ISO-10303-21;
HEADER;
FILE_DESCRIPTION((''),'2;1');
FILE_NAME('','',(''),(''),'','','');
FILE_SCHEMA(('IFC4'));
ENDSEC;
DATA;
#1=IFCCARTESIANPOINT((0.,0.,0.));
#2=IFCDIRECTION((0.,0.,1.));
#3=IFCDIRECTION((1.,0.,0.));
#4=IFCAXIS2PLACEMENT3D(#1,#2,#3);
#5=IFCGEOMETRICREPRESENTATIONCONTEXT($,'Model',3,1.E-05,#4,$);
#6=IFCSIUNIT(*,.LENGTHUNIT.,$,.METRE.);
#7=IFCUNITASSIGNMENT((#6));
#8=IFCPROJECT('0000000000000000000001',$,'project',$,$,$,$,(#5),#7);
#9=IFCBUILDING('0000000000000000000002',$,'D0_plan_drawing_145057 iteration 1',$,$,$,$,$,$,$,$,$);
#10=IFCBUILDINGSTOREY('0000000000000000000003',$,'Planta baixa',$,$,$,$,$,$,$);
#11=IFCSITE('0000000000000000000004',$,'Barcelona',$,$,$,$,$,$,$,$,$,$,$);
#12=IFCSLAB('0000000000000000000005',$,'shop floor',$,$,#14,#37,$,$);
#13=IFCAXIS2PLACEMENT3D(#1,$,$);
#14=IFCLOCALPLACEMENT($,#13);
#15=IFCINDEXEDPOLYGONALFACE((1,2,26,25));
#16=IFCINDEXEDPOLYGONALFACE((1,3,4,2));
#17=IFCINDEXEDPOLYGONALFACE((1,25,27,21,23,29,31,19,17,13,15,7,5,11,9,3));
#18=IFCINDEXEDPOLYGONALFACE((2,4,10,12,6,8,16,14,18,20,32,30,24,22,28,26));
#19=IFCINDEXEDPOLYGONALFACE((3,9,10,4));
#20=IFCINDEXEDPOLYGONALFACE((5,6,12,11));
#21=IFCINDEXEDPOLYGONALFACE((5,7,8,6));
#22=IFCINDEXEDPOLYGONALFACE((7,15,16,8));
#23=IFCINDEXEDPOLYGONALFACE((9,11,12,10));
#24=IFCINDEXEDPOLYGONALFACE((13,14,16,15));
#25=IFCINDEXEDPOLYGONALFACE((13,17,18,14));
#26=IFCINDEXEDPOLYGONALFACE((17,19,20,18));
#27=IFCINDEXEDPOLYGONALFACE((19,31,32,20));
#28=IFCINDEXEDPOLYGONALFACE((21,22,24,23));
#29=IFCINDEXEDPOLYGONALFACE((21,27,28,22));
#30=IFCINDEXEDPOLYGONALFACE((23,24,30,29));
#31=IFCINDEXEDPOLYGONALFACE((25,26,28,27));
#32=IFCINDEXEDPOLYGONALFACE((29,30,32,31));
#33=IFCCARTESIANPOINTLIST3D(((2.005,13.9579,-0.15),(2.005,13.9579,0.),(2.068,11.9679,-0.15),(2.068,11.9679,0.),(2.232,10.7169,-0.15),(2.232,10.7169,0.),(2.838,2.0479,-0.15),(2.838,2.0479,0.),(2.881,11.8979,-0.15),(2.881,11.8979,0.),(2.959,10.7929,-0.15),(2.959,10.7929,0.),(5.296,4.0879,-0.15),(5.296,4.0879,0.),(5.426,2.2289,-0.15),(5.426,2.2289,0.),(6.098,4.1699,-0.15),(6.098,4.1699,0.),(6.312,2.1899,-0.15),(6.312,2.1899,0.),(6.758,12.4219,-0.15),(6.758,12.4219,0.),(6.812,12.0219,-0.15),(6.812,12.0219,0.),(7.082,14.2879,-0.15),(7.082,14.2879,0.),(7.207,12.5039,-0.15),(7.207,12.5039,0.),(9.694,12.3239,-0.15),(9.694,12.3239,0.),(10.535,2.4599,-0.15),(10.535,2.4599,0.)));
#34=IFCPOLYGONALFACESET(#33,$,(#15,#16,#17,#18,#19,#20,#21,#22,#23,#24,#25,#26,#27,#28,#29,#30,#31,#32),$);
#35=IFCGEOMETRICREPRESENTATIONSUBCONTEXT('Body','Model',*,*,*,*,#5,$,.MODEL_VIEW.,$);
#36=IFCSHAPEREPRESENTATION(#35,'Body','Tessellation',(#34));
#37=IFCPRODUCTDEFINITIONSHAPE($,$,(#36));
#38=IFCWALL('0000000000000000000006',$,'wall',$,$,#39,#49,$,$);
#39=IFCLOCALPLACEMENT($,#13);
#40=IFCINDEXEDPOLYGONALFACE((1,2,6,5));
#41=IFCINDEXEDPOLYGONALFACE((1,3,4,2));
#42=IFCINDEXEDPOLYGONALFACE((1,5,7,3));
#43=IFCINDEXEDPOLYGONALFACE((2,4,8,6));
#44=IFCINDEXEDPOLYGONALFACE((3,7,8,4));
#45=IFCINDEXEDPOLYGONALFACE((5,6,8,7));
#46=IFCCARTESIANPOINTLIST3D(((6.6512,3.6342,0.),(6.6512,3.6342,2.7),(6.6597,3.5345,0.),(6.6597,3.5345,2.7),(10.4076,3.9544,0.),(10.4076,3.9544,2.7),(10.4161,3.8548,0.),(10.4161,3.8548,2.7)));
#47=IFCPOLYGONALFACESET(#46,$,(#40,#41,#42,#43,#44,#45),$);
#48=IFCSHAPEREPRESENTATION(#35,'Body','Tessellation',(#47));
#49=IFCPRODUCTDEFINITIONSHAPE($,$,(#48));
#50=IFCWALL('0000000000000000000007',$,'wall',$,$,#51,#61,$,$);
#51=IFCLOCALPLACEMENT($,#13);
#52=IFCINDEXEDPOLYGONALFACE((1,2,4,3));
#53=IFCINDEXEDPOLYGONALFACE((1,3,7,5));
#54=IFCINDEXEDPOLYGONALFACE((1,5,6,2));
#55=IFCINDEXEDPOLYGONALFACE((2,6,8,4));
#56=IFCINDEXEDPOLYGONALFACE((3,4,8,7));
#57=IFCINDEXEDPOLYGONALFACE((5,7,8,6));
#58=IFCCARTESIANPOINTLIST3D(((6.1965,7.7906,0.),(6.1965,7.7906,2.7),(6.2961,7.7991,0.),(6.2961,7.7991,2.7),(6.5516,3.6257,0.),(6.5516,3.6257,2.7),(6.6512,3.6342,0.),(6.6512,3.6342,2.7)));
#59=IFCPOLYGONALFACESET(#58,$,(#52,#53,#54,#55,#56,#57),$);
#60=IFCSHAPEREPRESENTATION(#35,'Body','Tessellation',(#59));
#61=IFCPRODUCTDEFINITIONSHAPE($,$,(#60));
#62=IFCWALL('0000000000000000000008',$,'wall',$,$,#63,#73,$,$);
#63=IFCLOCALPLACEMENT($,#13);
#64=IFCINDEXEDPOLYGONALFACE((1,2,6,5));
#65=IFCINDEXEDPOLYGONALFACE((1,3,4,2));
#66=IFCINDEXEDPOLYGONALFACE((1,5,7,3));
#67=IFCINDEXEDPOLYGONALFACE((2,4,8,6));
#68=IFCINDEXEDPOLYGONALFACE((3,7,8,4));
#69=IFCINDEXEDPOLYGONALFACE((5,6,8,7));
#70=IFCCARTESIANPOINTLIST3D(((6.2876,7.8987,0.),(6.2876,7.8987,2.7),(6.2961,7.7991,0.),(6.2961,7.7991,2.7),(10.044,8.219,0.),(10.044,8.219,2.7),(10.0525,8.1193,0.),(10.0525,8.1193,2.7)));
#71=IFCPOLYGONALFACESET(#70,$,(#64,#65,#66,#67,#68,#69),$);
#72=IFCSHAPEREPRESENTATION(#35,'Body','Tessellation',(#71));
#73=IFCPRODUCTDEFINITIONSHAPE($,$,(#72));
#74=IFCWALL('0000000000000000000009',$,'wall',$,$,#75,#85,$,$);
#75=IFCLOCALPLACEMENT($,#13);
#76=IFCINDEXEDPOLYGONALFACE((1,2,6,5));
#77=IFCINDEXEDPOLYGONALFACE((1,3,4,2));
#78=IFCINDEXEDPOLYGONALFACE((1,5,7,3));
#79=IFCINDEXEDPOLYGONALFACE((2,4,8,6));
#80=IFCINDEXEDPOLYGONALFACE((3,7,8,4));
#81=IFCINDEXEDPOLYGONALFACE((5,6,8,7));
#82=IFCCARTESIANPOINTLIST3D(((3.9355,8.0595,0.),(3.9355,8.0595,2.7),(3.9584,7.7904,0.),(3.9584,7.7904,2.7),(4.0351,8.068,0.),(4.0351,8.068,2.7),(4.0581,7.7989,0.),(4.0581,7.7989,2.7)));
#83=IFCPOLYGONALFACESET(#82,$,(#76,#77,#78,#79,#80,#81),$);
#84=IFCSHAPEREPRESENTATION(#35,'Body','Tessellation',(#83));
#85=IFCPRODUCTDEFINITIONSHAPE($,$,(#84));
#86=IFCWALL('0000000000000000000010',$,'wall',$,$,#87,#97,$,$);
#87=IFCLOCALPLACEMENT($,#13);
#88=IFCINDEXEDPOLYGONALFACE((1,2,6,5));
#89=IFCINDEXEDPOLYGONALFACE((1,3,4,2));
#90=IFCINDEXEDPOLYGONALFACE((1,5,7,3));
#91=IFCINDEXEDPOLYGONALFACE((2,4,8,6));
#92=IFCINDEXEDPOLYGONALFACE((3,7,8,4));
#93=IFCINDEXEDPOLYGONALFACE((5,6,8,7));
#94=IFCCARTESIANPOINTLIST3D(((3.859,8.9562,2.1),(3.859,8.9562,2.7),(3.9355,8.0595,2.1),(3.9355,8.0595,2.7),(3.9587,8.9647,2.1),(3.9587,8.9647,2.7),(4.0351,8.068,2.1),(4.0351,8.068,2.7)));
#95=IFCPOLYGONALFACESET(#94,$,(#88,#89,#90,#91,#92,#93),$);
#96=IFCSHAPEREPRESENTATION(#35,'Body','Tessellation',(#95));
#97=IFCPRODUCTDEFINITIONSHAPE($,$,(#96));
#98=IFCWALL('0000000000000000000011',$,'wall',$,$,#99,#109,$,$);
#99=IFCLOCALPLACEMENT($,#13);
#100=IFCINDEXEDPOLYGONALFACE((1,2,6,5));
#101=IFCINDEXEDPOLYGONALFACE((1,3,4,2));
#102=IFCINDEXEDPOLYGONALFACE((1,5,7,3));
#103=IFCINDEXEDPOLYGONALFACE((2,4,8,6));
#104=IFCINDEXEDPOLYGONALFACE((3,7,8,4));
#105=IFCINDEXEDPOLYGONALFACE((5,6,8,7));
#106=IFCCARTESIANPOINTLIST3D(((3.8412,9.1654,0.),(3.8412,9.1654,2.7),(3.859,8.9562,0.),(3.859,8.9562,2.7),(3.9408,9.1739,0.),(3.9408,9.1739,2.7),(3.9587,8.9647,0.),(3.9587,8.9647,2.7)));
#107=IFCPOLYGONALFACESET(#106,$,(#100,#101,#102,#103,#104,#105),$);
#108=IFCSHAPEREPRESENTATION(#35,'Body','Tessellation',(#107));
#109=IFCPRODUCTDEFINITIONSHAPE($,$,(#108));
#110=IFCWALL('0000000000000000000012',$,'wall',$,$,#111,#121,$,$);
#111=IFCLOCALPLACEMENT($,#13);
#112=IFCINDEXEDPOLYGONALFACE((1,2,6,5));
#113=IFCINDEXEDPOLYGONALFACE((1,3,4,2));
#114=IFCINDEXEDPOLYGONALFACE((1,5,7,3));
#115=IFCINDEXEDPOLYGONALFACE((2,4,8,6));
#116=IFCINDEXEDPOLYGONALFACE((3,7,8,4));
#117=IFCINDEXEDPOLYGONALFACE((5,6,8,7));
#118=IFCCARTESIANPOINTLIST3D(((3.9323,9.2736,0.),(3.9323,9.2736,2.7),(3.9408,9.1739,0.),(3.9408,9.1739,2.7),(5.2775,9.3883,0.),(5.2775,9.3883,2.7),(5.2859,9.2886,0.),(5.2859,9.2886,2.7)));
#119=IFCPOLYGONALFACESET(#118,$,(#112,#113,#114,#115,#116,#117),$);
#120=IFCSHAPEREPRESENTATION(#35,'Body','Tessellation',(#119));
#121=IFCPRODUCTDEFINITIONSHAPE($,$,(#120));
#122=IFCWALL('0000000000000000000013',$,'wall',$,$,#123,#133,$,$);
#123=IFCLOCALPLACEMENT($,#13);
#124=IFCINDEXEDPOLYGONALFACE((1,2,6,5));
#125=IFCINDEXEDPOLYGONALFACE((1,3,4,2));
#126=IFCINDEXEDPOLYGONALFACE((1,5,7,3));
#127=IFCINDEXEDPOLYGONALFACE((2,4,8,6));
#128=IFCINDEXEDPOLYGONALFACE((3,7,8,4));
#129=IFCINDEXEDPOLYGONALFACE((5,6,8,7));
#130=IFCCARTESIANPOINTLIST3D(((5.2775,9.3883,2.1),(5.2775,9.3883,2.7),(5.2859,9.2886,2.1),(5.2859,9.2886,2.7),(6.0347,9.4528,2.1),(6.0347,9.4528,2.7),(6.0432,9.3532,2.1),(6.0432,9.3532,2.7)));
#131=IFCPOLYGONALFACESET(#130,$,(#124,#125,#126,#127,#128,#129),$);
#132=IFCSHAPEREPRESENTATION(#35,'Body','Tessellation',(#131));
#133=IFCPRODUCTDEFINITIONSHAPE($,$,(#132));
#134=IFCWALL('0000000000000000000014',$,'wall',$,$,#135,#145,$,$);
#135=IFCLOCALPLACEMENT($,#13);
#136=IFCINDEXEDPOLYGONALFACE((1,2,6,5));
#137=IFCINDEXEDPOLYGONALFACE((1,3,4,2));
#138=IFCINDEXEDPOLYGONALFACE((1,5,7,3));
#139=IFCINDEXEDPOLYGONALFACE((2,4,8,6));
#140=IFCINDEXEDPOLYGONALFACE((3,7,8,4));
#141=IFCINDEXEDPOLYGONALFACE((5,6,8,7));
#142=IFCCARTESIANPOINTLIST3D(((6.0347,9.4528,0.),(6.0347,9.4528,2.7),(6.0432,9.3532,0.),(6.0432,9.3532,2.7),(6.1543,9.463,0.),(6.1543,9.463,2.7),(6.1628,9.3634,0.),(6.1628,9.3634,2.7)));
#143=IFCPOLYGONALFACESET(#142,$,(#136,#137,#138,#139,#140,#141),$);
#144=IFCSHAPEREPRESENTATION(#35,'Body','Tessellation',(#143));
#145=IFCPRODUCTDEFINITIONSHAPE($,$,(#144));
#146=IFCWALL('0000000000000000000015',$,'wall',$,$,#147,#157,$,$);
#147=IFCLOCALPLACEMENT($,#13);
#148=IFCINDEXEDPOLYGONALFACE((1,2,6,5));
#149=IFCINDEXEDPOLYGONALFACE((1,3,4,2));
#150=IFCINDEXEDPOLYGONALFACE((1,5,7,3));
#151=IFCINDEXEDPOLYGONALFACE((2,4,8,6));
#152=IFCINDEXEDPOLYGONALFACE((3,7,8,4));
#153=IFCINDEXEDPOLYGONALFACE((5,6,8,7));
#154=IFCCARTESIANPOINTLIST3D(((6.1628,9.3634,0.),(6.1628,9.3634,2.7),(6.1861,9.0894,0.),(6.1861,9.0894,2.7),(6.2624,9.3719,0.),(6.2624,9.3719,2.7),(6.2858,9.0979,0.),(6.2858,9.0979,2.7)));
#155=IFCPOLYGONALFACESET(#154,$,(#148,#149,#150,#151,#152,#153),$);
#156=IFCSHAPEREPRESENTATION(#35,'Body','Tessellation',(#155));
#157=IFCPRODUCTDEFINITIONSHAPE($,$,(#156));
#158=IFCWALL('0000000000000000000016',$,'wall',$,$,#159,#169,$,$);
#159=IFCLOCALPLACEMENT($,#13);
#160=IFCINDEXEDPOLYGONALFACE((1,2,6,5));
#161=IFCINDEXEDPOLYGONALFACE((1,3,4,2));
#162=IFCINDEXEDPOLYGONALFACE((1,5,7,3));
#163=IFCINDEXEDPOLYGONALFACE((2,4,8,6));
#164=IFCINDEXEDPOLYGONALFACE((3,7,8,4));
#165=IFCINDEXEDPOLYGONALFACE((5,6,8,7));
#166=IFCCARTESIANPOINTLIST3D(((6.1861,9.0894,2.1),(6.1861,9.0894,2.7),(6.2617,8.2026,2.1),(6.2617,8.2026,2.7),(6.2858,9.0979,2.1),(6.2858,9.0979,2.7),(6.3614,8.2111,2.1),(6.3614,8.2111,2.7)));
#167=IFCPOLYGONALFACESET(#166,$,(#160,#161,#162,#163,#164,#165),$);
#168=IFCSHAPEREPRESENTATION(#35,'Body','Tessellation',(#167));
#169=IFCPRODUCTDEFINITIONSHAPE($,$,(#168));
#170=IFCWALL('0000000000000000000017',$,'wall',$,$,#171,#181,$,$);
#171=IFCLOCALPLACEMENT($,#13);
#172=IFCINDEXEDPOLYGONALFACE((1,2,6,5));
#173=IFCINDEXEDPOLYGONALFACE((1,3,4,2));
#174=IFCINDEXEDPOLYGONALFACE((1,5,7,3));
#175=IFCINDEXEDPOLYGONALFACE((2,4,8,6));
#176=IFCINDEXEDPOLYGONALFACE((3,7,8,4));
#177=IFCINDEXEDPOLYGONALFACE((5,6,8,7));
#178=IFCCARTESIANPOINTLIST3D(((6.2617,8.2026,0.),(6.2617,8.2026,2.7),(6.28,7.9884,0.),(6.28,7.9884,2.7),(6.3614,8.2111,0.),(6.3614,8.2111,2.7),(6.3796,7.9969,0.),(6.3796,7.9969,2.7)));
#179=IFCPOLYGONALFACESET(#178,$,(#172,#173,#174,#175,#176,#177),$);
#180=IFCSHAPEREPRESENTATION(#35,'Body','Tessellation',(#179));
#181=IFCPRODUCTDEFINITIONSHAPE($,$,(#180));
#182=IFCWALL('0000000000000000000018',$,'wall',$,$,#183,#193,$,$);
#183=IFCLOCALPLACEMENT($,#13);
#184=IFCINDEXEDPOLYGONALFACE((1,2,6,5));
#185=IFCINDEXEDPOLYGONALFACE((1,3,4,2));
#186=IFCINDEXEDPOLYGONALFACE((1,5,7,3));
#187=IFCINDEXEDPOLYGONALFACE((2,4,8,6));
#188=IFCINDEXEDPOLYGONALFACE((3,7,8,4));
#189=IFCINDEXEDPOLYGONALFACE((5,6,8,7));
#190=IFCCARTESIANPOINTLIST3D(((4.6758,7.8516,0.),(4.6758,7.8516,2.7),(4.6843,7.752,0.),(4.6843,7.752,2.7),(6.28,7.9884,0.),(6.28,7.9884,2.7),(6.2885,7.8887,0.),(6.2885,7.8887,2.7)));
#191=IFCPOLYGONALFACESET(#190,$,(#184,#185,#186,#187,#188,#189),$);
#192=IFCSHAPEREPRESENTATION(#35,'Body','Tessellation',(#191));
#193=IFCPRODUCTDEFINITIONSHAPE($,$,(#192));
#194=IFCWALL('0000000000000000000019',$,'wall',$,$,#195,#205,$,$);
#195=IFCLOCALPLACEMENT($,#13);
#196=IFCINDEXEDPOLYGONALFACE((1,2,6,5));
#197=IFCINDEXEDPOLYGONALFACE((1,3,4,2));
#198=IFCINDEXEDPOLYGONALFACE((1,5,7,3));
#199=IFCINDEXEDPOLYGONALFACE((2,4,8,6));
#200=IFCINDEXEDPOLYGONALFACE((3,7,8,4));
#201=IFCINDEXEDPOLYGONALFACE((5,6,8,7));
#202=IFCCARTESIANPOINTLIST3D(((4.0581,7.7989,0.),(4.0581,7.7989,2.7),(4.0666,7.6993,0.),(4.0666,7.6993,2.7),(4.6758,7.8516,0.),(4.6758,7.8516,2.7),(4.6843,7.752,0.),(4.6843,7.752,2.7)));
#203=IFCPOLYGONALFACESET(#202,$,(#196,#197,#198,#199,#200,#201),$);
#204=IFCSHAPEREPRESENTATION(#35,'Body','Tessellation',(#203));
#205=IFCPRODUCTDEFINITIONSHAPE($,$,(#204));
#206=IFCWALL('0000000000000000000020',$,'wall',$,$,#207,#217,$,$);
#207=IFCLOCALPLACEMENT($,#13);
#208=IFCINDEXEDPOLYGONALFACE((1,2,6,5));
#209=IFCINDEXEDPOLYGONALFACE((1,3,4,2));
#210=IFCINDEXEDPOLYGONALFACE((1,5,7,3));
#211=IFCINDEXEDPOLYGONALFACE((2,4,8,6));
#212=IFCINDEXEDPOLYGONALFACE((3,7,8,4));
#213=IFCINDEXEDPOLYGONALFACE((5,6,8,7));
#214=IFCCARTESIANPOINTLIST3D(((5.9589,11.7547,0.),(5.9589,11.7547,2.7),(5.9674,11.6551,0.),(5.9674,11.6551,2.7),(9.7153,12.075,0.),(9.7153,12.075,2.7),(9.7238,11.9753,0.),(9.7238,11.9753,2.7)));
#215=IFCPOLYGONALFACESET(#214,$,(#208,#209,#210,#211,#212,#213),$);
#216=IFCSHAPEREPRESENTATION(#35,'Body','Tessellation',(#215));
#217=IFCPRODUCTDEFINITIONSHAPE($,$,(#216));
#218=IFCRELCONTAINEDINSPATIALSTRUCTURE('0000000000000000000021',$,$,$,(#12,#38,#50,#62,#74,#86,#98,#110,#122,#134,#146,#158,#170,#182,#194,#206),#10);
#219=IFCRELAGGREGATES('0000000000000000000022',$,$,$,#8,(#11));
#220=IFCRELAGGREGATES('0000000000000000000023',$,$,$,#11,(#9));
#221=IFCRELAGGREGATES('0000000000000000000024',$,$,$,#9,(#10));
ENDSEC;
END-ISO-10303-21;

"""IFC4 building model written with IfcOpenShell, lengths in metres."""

from ifc_helpers import new_model, si_unit, frame, origin, origin_with_axes, place, context, subcontext, project, spatial, polyline, outline, extrude, element, save


model = new_model("IFC4")

# Units and contexts
model_context = context("Model", 3, precision=1e-05, world=origin_with_axes())
body_context = subcontext(model_context, "Body", "Model", "MODEL_VIEW")
ifc_project = project(units=[si_unit("LENGTHUNIT", "METRE")], contexts=[model_context])

# Site, building, storey
site = spatial("IfcSite", under=ifc_project, Name="Barcelona")
building = spatial("IfcBuilding", under=site, Name="D0_plan_drawing_145057 iteration 1")
storey = spatial("IfcBuildingStorey", under=building, Name="Planta baixa")

# Slab
slab_placement = place(None, origin_with_axes())
element("IfcSlab", 1, at=slab_placement, inside=storey, Name="shop floor", context=body_context, shape_type="SweptSolid", body=[
    extrude(outline(polyline([(2.005, 13.9579), (2.068, 11.9679), (2.881, 11.8979), (2.959, 10.7929), (2.232, 10.7169), (2.838, 2.0479), (5.426, 2.2289), (5.296, 4.0879), (6.098, 4.1699), (6.312, 2.1899), (10.535, 2.4599), (9.694, 12.3239), (6.812, 12.0219), (6.758, 12.4219), (7.207, 12.5039), (7.082, 14.2879), (2.005, 13.9579)])), frame((0.0, 0.0, -0.15)), (0.0, 0.0, 1.0), 0.15),
])

# Walls
wall_1_placement = place(None, origin_with_axes())
element("IfcWall", 2, at=wall_1_placement, inside=storey, Name="wall", context=body_context, shape_type="SweptSolid", body=[
    extrude(outline(polyline([(10.4161, 3.8548), (6.6597, 3.5345), (6.6512, 3.6342), (10.4076, 3.9544), (10.4161, 3.8548)])), origin(), (0.0, 0.0, 1.0), 2.7),
])
wall_2_placement = place(None, origin_with_axes())
element("IfcWall", 3, at=wall_2_placement, inside=storey, Name="wall", context=body_context, shape_type="SweptSolid", body=[
    extrude(outline(polyline([(6.5516, 3.6257), (6.1965, 7.7906), (6.2961, 7.7991), (6.6512, 3.6342), (6.5516, 3.6257)])), origin(), (0.0, 0.0, 1.0), 2.7),
])
wall_3_placement = place(None, origin_with_axes())
element("IfcWall", 4, at=wall_3_placement, inside=storey, Name="wall", context=body_context, shape_type="SweptSolid", body=[
    extrude(outline(polyline([(6.2876, 7.8987), (10.044, 8.219), (10.0525, 8.1193), (6.2961, 7.7991), (6.2876, 7.8987)])), origin(), (0.0, 0.0, 1.0), 2.7),
])
wall_4_placement = place(None, origin_with_axes())
element("IfcWall", 5, at=wall_4_placement, inside=storey, Name="wall", context=body_context, shape_type="SweptSolid", body=[
    extrude(outline(polyline([(3.9584, 7.7904), (3.9355, 8.0595), (4.0351, 8.068), (4.0581, 7.7989), (3.9584, 7.7904)])), origin(), (0.0, 0.0, 1.0), 2.7),
])
wall_5_placement = place(None, origin_with_axes())
element("IfcWall", 6, at=wall_5_placement, inside=storey, Name="wall", context=body_context, shape_type="SweptSolid", body=[
    extrude(outline(polyline([(3.9355, 8.0595), (3.859, 8.9562), (3.9587, 8.9647), (4.0351, 8.068), (3.9355, 8.0595)])), frame((0.0, 0.0, 2.1)), (0.0, 0.0, 1.0), 0.6),
])
wall_6_placement = place(None, origin_with_axes())
element("IfcWall", 7, at=wall_6_placement, inside=storey, Name="wall", context=body_context, shape_type="SweptSolid", body=[
    extrude(outline(polyline([(3.859, 8.9562), (3.8412, 9.1654), (3.9408, 9.1739), (3.9587, 8.9647), (3.859, 8.9562)])), origin(), (0.0, 0.0, 1.0), 2.7),
])
wall_7_placement = place(None, origin_with_axes())
element("IfcWall", 8, at=wall_7_placement, inside=storey, Name="wall", context=body_context, shape_type="SweptSolid", body=[
    extrude(outline(polyline([(3.9323, 9.2736), (5.2775, 9.3883), (5.2859, 9.2886), (3.9408, 9.1739), (3.9323, 9.2736)])), origin(), (0.0, 0.0, 1.0), 2.7),
])
wall_8_placement = place(None, origin_with_axes())
element("IfcWall", 9, at=wall_8_placement, inside=storey, Name="wall", context=body_context, shape_type="SweptSolid", body=[
    extrude(outline(polyline([(5.2775, 9.3883), (6.0347, 9.4528), (6.0432, 9.3532), (5.2859, 9.2886), (5.2775, 9.3883)])), frame((0.0, 0.0, 2.1)), (0.0, 0.0, 1.0), 0.6),
])
wall_9_placement = place(None, origin_with_axes())
element("IfcWall", 10, at=wall_9_placement, inside=storey, Name="wall", context=body_context, shape_type="SweptSolid", body=[
    extrude(outline(polyline([(6.0347, 9.4528), (6.1543, 9.463), (6.1628, 9.3634), (6.0432, 9.3532), (6.0347, 9.4528)])), origin(), (0.0, 0.0, 1.0), 2.7),
])
wall_10_placement = place(None, origin_with_axes())
element("IfcWall", 11, at=wall_10_placement, inside=storey, Name="wall", context=body_context, shape_type="SweptSolid", body=[
    extrude(outline(polyline([(6.2624, 9.3719), (6.2858, 9.0979), (6.1861, 9.0894), (6.1628, 9.3634), (6.2624, 9.3719)])), origin(), (0.0, 0.0, 1.0), 2.7),
])
wall_11_placement = place(None, origin_with_axes())
element("IfcWall", 12, at=wall_11_placement, inside=storey, Name="wall", context=body_context, shape_type="SweptSolid", body=[
    extrude(outline(polyline([(6.2858, 9.0979), (6.3614, 8.2111), (6.2617, 8.2026), (6.1861, 9.0894), (6.2858, 9.0979)])), frame((0.0, 0.0, 2.1)), (0.0, 0.0, 1.0), 0.6),
])
wall_12_placement = place(None, origin_with_axes())
element("IfcWall", 13, at=wall_12_placement, inside=storey, Name="wall", context=body_context, shape_type="SweptSolid", body=[
    extrude(outline(polyline([(6.3614, 8.2111), (6.3796, 7.9969), (6.28, 7.9884), (6.2617, 8.2026), (6.3614, 8.2111)])), origin(), (0.0, 0.0, 1.0), 2.7),
])
wall_13_placement = place(None, origin_with_axes())
element("IfcWall", 14, at=wall_13_placement, inside=storey, Name="wall", context=body_context, shape_type="SweptSolid", body=[
    extrude(outline(polyline([(6.2885, 7.8887), (4.6843, 7.752), (4.6758, 7.8516), (6.28, 7.9884), (6.2885, 7.8887)])), origin(), (0.0, 0.0, 1.0), 2.7),
])
wall_14_placement = place(None, origin_with_axes())
element("IfcWall", 15, at=wall_14_placement, inside=storey, Name="wall", context=body_context, shape_type="SweptSolid", body=[
    extrude(outline(polyline([(4.6843, 7.752), (4.0666, 7.6993), (4.0581, 7.7989), (4.6758, 7.8516), (4.6843, 7.752)])), origin(), (0.0, 0.0, 1.0), 2.7),
])
wall_15_placement = place(None, origin_with_axes())
element("IfcWall", 16, at=wall_15_placement, inside=storey, Name="wall", context=body_context, shape_type="SweptSolid", body=[
    extrude(outline(polyline([(5.9589, 11.7547), (9.7153, 12.075), (9.7238, 11.9753), (5.9674, 11.6551), (5.9589, 11.7547)])), origin(), (0.0, 0.0, 1.0), 2.7),
])

save(model, "model.ifc")
